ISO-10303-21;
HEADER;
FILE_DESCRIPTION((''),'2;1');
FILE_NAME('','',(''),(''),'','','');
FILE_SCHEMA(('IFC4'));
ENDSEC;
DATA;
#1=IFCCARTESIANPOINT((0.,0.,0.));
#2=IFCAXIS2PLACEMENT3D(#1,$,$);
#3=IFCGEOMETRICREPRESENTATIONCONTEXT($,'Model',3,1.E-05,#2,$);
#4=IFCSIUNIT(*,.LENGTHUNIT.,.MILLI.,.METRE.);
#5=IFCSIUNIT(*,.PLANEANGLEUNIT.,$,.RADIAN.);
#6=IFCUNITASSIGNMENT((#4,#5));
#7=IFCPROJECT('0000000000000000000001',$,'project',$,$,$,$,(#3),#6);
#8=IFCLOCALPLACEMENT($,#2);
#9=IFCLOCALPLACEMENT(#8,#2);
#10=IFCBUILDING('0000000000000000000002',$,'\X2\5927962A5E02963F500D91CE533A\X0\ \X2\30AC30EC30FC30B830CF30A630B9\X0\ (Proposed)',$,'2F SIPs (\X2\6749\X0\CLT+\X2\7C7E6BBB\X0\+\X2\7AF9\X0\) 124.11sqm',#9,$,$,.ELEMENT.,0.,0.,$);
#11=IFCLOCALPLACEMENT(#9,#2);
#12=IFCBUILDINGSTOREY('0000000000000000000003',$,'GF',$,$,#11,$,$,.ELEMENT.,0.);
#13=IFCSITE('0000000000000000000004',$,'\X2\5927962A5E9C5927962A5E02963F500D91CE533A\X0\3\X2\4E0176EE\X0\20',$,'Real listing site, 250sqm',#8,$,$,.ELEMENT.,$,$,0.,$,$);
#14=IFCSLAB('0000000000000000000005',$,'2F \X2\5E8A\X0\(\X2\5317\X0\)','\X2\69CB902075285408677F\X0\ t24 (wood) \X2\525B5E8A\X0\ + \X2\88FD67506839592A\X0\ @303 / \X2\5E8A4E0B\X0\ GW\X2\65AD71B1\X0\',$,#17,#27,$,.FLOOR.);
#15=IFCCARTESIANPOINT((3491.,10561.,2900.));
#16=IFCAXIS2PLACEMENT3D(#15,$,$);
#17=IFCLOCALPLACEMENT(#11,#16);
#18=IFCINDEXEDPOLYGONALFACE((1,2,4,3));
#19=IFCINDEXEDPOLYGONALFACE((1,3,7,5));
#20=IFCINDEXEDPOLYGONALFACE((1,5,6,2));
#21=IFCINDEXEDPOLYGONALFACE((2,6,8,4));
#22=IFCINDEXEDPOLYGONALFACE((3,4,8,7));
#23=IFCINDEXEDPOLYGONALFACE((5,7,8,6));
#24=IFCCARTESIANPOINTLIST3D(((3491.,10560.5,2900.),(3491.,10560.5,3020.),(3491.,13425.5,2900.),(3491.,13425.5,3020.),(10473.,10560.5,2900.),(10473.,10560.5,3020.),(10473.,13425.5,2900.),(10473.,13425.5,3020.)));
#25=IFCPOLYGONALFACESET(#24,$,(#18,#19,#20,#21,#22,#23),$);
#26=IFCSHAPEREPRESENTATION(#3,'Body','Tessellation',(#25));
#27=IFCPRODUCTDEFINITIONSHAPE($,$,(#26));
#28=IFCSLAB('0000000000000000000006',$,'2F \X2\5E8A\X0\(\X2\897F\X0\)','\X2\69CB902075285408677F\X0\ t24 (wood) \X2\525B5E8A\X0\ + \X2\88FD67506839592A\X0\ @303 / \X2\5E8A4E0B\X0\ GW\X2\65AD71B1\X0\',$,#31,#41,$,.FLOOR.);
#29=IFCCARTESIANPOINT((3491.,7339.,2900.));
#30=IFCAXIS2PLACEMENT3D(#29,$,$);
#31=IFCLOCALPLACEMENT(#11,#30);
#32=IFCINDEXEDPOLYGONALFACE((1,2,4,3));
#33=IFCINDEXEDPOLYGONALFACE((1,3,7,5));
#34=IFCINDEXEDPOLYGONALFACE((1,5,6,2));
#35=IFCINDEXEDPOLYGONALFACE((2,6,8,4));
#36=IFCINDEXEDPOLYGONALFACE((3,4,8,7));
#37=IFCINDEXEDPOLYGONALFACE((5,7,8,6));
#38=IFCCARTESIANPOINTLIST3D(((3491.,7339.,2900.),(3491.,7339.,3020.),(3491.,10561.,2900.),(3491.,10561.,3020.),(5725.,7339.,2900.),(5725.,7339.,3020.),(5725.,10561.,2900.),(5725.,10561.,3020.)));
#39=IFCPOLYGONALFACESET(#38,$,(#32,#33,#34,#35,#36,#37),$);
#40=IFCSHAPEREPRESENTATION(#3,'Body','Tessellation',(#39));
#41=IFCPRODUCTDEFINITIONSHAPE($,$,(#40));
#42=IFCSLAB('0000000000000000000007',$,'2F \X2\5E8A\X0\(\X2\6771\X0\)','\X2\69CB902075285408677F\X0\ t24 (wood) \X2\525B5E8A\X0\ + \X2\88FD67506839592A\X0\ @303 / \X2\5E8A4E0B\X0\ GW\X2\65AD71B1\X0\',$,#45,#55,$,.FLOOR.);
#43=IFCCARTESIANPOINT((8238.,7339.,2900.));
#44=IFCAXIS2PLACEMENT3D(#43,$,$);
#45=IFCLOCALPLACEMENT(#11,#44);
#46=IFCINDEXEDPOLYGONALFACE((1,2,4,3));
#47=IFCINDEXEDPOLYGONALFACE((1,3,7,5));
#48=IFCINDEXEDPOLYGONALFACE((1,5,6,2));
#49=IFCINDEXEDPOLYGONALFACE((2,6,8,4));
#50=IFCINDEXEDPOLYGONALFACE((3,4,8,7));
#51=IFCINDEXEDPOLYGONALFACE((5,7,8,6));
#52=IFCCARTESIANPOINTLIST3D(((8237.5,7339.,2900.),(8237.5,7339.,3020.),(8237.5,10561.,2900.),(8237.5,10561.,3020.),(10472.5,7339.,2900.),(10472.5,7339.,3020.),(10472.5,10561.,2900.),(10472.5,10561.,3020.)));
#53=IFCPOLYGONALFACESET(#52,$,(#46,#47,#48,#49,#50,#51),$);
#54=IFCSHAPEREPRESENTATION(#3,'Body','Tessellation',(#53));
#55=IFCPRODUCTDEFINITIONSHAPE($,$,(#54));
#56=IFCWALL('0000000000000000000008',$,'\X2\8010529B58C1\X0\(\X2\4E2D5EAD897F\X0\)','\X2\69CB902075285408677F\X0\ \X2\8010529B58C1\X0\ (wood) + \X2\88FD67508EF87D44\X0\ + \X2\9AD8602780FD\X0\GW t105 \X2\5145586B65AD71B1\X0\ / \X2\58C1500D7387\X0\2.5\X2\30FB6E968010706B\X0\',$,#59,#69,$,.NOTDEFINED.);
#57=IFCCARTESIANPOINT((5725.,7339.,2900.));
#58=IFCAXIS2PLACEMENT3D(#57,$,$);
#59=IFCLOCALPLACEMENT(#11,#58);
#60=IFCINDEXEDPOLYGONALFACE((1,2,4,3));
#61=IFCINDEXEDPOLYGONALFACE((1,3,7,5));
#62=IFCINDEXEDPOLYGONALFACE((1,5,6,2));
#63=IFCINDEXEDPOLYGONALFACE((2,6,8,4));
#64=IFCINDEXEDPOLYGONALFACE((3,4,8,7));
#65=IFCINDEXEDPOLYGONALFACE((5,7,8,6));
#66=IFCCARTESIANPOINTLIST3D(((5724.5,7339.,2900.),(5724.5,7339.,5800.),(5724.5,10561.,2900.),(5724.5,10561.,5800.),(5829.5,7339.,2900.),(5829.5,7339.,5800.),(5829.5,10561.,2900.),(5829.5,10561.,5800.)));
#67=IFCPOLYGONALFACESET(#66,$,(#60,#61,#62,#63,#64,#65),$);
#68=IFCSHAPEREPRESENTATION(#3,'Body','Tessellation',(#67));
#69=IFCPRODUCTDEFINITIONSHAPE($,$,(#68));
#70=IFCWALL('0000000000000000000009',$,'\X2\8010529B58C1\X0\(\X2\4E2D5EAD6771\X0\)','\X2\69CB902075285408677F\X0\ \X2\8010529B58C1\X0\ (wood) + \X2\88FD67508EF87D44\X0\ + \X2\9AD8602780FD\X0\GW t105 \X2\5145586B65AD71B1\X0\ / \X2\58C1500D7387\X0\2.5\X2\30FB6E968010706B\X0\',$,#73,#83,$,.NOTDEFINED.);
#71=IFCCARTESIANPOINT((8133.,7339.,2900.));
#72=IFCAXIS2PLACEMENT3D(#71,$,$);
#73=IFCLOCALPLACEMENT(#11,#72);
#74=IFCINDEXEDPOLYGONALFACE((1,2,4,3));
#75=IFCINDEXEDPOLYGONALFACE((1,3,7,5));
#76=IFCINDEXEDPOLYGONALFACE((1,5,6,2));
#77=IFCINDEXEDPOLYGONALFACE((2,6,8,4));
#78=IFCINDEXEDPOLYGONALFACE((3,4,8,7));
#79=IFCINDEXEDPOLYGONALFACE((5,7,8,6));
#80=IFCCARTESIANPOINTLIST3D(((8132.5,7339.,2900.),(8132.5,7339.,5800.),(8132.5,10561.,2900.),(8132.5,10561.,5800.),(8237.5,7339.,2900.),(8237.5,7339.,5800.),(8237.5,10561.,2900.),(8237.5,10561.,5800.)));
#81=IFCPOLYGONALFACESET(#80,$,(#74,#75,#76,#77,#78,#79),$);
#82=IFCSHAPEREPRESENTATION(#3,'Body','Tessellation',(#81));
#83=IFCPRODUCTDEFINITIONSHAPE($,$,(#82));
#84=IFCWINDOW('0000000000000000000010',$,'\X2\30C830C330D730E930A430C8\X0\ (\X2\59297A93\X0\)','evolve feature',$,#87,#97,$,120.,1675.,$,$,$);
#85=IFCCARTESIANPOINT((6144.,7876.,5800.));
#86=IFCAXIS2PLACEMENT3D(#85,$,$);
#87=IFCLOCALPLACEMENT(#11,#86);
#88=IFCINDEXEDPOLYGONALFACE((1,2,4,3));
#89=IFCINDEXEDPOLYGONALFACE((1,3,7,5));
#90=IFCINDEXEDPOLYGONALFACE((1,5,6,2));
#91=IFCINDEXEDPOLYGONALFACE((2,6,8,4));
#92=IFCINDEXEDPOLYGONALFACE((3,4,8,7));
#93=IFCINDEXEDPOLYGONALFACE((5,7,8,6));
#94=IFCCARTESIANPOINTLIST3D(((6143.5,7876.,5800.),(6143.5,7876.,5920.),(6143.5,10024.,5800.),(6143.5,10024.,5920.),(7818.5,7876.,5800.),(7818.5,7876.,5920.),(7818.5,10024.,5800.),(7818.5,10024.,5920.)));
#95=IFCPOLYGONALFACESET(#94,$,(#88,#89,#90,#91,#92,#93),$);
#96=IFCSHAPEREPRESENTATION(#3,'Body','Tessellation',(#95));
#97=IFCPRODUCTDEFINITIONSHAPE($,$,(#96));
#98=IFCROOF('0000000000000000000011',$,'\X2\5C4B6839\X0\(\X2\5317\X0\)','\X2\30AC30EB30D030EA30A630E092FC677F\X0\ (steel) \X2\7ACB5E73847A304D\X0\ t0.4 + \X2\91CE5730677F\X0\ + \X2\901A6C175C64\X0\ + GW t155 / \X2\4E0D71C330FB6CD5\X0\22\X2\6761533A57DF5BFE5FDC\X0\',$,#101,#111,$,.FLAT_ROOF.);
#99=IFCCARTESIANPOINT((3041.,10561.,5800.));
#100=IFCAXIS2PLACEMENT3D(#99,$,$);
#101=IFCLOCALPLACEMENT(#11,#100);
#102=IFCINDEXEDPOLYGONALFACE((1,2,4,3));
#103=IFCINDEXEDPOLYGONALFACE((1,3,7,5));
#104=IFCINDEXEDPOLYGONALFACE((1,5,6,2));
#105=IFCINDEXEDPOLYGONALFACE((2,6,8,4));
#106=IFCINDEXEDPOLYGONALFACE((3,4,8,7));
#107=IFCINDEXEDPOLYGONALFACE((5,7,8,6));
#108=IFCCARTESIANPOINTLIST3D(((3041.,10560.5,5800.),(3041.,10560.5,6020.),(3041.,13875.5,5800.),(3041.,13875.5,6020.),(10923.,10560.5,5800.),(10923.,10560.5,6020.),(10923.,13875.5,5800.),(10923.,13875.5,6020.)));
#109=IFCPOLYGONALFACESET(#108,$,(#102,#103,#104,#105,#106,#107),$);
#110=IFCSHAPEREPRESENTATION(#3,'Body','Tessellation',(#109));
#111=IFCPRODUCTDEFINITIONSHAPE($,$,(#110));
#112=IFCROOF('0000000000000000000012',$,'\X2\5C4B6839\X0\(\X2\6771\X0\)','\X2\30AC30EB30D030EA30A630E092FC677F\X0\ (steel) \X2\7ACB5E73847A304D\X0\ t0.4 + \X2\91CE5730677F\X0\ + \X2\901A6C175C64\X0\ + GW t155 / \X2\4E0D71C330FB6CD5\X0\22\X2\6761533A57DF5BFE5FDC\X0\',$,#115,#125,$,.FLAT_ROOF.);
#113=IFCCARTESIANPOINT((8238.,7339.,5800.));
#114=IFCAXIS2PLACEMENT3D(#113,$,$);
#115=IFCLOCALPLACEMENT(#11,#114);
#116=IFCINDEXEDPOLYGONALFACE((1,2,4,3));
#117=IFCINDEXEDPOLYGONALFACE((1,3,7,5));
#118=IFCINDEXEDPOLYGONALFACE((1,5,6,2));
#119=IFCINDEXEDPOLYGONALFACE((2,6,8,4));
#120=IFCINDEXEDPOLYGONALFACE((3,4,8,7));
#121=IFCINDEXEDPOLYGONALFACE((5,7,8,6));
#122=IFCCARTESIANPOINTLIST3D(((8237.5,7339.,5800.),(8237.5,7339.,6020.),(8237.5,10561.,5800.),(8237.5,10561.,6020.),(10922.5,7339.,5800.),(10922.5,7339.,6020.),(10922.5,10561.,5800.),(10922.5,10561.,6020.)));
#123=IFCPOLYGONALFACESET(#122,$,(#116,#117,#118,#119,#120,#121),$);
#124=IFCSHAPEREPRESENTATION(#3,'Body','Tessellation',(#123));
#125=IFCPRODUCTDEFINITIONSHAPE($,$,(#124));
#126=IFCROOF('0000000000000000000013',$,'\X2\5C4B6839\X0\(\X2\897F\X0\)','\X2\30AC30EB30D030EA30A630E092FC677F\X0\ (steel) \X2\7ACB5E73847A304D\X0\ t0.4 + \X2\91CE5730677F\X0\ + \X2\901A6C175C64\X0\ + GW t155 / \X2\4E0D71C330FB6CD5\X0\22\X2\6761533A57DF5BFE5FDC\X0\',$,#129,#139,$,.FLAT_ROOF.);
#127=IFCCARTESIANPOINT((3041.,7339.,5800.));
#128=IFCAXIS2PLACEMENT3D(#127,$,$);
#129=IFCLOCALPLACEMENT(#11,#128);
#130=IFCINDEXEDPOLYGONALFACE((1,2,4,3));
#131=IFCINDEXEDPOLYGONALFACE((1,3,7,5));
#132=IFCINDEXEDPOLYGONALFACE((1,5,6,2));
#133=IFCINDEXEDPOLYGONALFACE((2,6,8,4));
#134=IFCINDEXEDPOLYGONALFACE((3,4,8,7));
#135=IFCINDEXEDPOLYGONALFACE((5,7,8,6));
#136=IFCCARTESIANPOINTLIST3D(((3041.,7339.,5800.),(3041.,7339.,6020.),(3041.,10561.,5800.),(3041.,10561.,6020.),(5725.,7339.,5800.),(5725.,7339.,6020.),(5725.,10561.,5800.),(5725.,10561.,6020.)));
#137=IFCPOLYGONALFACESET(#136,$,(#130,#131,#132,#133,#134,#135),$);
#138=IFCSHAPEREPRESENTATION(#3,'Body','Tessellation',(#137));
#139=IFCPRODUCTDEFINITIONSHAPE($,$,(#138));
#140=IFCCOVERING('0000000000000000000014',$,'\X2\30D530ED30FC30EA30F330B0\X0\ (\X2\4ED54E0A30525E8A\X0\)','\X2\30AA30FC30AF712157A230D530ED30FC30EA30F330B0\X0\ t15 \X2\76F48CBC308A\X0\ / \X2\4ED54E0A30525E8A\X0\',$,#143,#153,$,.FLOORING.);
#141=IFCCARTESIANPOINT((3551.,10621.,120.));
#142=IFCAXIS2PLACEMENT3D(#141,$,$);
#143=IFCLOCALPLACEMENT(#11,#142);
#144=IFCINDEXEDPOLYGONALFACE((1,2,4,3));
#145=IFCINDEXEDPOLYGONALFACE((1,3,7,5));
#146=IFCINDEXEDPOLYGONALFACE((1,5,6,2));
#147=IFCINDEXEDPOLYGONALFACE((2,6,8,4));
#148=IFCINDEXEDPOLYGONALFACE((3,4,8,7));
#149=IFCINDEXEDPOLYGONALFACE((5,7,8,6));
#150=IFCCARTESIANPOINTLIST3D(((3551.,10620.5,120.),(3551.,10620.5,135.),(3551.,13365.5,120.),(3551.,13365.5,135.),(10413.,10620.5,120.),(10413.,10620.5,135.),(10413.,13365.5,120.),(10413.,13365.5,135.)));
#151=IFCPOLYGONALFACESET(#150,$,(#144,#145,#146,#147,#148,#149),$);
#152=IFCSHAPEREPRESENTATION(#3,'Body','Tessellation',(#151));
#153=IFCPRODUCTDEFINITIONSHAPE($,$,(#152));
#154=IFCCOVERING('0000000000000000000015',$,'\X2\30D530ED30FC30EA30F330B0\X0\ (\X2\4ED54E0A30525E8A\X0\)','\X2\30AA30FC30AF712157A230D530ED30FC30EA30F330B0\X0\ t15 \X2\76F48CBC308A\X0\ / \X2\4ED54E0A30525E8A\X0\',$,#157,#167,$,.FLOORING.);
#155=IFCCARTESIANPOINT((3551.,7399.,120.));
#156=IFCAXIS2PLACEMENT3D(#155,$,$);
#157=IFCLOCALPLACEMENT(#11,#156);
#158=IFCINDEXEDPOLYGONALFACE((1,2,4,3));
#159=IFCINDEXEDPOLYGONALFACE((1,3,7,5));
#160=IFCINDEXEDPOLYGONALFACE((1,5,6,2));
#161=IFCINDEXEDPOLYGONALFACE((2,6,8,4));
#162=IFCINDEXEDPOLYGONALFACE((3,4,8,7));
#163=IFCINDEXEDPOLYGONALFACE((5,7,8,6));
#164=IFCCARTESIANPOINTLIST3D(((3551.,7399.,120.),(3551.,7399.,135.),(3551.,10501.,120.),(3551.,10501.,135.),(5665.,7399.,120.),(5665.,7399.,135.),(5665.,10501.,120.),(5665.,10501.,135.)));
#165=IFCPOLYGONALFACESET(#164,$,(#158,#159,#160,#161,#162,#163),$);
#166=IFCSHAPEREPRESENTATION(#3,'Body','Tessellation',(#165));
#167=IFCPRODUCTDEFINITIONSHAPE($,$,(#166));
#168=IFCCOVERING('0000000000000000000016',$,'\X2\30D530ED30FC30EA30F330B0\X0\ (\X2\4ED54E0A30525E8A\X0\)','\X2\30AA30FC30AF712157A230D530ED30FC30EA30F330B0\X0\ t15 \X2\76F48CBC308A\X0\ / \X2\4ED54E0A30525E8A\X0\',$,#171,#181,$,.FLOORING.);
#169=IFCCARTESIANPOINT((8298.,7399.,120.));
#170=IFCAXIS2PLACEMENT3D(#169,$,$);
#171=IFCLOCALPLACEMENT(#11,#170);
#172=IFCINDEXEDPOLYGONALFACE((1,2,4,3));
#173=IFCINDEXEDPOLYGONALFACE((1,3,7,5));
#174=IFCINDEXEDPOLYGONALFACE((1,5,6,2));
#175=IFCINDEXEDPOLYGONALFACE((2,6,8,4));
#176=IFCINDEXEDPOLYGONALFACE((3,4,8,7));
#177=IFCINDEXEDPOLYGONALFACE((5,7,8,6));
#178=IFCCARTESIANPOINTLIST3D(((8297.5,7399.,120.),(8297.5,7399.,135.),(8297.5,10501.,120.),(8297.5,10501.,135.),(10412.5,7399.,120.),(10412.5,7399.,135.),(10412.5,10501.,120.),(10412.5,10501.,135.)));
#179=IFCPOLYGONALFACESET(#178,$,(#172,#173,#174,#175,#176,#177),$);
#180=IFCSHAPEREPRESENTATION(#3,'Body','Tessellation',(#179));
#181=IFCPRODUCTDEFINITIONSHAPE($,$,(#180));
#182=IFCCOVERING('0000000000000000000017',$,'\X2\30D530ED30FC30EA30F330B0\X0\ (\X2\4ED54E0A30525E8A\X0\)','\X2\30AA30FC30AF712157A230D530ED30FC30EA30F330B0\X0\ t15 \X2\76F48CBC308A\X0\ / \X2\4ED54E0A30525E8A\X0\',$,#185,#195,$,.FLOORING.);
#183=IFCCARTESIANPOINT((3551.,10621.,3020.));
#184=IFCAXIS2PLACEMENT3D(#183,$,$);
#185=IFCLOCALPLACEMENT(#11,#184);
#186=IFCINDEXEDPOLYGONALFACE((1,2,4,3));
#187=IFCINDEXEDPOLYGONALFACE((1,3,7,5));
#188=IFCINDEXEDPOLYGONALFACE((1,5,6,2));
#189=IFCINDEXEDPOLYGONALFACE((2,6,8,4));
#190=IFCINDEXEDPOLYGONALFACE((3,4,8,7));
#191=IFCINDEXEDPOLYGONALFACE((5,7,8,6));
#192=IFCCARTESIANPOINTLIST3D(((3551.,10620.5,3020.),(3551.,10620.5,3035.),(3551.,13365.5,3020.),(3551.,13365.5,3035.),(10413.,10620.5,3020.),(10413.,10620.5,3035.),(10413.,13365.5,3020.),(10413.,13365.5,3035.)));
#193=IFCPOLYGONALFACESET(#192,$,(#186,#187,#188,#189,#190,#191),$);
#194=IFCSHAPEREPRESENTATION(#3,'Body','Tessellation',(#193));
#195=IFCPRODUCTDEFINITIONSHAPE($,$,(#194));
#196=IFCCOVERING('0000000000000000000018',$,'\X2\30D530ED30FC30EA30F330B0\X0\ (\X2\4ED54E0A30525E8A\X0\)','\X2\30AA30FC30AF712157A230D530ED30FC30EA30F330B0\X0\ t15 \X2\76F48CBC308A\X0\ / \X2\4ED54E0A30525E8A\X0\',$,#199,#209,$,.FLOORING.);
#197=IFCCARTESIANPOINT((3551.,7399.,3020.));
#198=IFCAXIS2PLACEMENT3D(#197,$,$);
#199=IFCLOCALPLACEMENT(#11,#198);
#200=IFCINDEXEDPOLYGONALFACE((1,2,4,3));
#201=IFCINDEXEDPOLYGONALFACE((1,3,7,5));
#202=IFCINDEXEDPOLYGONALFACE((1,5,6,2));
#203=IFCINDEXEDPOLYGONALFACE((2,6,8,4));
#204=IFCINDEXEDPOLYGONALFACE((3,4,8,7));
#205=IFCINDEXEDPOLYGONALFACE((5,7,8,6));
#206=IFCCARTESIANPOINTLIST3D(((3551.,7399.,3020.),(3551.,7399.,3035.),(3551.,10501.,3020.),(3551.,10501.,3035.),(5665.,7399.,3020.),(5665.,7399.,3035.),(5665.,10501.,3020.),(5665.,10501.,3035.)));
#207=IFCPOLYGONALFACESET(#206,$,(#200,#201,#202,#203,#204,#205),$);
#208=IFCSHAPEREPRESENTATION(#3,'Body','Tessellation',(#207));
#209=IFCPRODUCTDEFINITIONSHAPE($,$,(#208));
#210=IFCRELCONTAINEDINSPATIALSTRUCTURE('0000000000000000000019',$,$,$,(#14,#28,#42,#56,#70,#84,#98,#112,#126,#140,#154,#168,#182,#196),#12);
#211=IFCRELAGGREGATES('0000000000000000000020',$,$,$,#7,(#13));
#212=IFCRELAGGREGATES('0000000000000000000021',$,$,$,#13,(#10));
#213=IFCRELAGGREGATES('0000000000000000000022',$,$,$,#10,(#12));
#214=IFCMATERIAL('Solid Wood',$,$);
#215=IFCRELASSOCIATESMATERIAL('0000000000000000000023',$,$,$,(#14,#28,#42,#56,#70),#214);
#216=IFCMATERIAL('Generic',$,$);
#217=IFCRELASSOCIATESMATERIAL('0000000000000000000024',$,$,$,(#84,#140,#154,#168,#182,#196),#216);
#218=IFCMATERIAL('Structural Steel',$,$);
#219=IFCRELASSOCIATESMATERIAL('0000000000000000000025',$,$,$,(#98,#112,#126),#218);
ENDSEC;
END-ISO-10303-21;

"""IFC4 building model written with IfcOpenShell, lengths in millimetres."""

from ifc_helpers import new_model, si_unit, frame, frame_2d, origin, place, context, project, spatial, rectangle, extrude, material, element, save


model = new_model("IFC4")

# Units and contexts
model_context = context("Model", 3, precision=1e-05, world=origin())
ifc_project = project(units=[si_unit("LENGTHUNIT", "METRE", prefix="MILLI"), si_unit("PLANEANGLEUNIT", "RADIAN")], contexts=[model_context])

# Site, building, storey
site_placement = place(None, origin())
site = spatial("IfcSite", under=ifc_project, at=site_placement, Name="大阪府大阪市阿倍野区3丁目20", ObjectType="Real listing site, 250sqm", CompositionType="ELEMENT", RefElevation=0.0)
building_placement = place(site_placement, origin())
building = spatial("IfcBuilding", under=site, at=building_placement, Name="大阪市阿倍野区 ガレージハウス (Proposed)", ObjectType="2F SIPs (杉CLT+籾殻+竹) 124.11sqm", CompositionType="ELEMENT", ElevationOfRefHeight=0.0, ElevationOfTerrain=0.0)
storey_placement = place(building_placement, origin())
storey = spatial("IfcBuildingStorey", under=building, at=storey_placement, Name="GF", CompositionType="ELEMENT", Elevation=0.0)

# Slabs
ifc_material_1 = material(Name="Solid Wood")
slab_1_placement = place(storey_placement, frame((3491.0, 10561.0, 2900.0)))
element("IfcSlab", 1, at=slab_1_placement, inside=storey, material=ifc_material_1, Name="2F 床(北)", Description="構造用合板 t24 (wood) 剛床 + 製材根太 @303 / 床下 GW断熱", PredefinedType="FLOOR", context=model_context, shape_type="SweptSolid", body=[
    extrude(rectangle(XDim=6982.0, YDim=2865.0, at=frame_2d((3491.0, 1432.0))), frame((3491.0, 10561.0, 2900.0)), (0.0, 0.0, 1.0), 120.0),
])
slab_2_placement = place(storey_placement, frame((3491.0, 7339.0, 2900.0)))
element("IfcSlab", 2, at=slab_2_placement, inside=storey, material=ifc_material_1, Name="2F 床(西)", Description="構造用合板 t24 (wood) 剛床 + 製材根太 @303 / 床下 GW断熱", PredefinedType="FLOOR", context=model_context, shape_type="SweptSolid", body=[
    extrude(rectangle(XDim=2234.0, YDim=3222.0, at=frame_2d((1117.0, 1611.0))), frame((3491.0, 7339.0, 2900.0)), (0.0, 0.0, 1.0), 120.0),
])
slab_3_placement = place(storey_placement, frame((8238.0, 7339.0, 2900.0)))
element("IfcSlab", 3, at=slab_3_placement, inside=storey, material=ifc_material_1, Name="2F 床(東)", Description="構造用合板 t24 (wood) 剛床 + 製材根太 @303 / 床下 GW断熱", PredefinedType="FLOOR", context=model_context, shape_type="SweptSolid", body=[
    extrude(rectangle(XDim=2235.0, YDim=3222.0, at=frame_2d((1117.0, 1611.0))), frame((8238.0, 7339.0, 2900.0)), (0.0, 0.0, 1.0), 120.0),
])

# Walls
wall_1_placement = place(storey_placement, frame((5725.0, 7339.0, 2900.0)))
element("IfcWall", 4, at=wall_1_placement, inside=storey, material=ifc_material_1, Name="耐力壁(中庭西)", Description="構造用合板 耐力壁 (wood) + 製材軸組 + 高性能GW t105 充填断熱 / 壁倍率2.5・準耐火", PredefinedType="NOTDEFINED", context=model_context, shape_type="SweptSolid", body=[
    extrude(rectangle(XDim=105.0, YDim=3222.0, at=frame_2d((52.0, 1611.0))), frame((5725.0, 7339.0, 2900.0)), (0.0, 0.0, 1.0), 2900.0),
])
wall_2_placement = place(storey_placement, frame((8133.0, 7339.0, 2900.0)))
element("IfcWall", 5, at=wall_2_placement, inside=storey, material=ifc_material_1, Name="耐力壁(中庭東)", Description="構造用合板 耐力壁 (wood) + 製材軸組 + 高性能GW t105 充填断熱 / 壁倍率2.5・準耐火", PredefinedType="NOTDEFINED", context=model_context, shape_type="SweptSolid", body=[
    extrude(rectangle(XDim=105.0, YDim=3222.0, at=frame_2d((52.0, 1611.0))), frame((8133.0, 7339.0, 2900.0)), (0.0, 0.0, 1.0), 2900.0),
])

# Window
ifc_material_2 = material(Name="Generic")
window_1_placement = place(storey_placement, frame((6144.0, 7876.0, 5800.0)))
element("IfcWindow", 6, at=window_1_placement, inside=storey, material=ifc_material_2, Name="トップライト (天窓)", Description="evolve feature", OverallHeight=120.0, OverallWidth=1675.0, context=model_context, shape_type="SweptSolid", body=[
    extrude(rectangle(XDim=1675.0, YDim=2148.0, at=frame_2d((837.0, 1074.0))), frame((6144.0, 7876.0, 5800.0)), (0.0, 0.0, 1.0), 120.0),
])

# Roofs
ifc_material_3 = material(Name="Structural Steel")
roof_1_placement = place(storey_placement, frame((3041.0, 10561.0, 5800.0)))
element("IfcRoof", 7, at=roof_1_placement, inside=storey, material=ifc_material_3, Name="屋根(北)", Description="ガルバリウム鋼板 (steel) 立平葺き t0.4 + 野地板 + 通気層 + GW t155 / 不燃・法22条区域対応", PredefinedType="FLAT_ROOF", context=model_context, shape_type="SweptSolid", body=[
    extrude(rectangle(XDim=7882.0, YDim=3315.0, at=frame_2d((3941.0, 1657.0))), frame((3041.0, 10561.0, 5800.0)), (0.0, 0.0, 1.0), 220.0),
])
roof_2_placement = place(storey_placement, frame((8238.0, 7339.0, 5800.0)))
element("IfcRoof", 8, at=roof_2_placement, inside=storey, material=ifc_material_3, Name="屋根(東)", Description="ガルバリウム鋼板 (steel) 立平葺き t0.4 + 野地板 + 通気層 + GW t155 / 不燃・法22条区域対応", PredefinedType="FLAT_ROOF", context=model_context, shape_type="SweptSolid", body=[
    extrude(rectangle(XDim=2685.0, YDim=3222.0, at=frame_2d((1342.0, 1611.0))), frame((8238.0, 7339.0, 5800.0)), (0.0, 0.0, 1.0), 220.0),
])
roof_3_placement = place(storey_placement, frame((3041.0, 7339.0, 5800.0)))
element("IfcRoof", 9, at=roof_3_placement, inside=storey, material=ifc_material_3, Name="屋根(西)", Description="ガルバリウム鋼板 (steel) 立平葺き t0.4 + 野地板 + 通気層 + GW t155 / 不燃・法22条区域対応", PredefinedType="FLAT_ROOF", context=model_context, shape_type="SweptSolid", body=[
    extrude(rectangle(XDim=2684.0, YDim=3222.0, at=frame_2d((1342.0, 1611.0))), frame((3041.0, 7339.0, 5800.0)), (0.0, 0.0, 1.0), 220.0),
])

# Coverings
covering_1_placement = place(storey_placement, frame((3551.0, 10621.0, 120.0)))
element("IfcCovering", 10, at=covering_1_placement, inside=storey, material=ifc_material_2, Name="フローリング (仕上げ床)", Description="オーク無垢フローリング t15 直貼り / 仕上げ床", PredefinedType="FLOORING", context=model_context, shape_type="SweptSolid", body=[
    extrude(rectangle(XDim=6862.0, YDim=2745.0, at=frame_2d((3431.0, 1372.0))), frame((3551.0, 10621.0, 120.0)), (0.0, 0.0, 1.0), 15.0),
])
covering_2_placement = place(storey_placement, frame((3551.0, 7399.0, 120.0)))
element("IfcCovering", 11, at=covering_2_placement, inside=storey, material=ifc_material_2, Name="フローリング (仕上げ床)", Description="オーク無垢フローリング t15 直貼り / 仕上げ床", PredefinedType="FLOORING", context=model_context, shape_type="SweptSolid", body=[
    extrude(rectangle(XDim=2114.0, YDim=3102.0, at=frame_2d((1057.0, 1551.0))), frame((3551.0, 7399.0, 120.0)), (0.0, 0.0, 1.0), 15.0),
])
covering_3_placement = place(storey_placement, frame((8298.0, 7399.0, 120.0)))
element("IfcCovering", 12, at=covering_3_placement, inside=storey, material=ifc_material_2, Name="フローリング (仕上げ床)", Description="オーク無垢フローリング t15 直貼り / 仕上げ床", PredefinedType="FLOORING", context=model_context, shape_type="SweptSolid", body=[
    extrude(rectangle(XDim=2115.0, YDim=3102.0, at=frame_2d((1057.0, 1551.0))), frame((8298.0, 7399.0, 120.0)), (0.0, 0.0, 1.0), 15.0),
])
covering_4_placement = place(storey_placement, frame((3551.0, 10621.0, 3020.0)))
element("IfcCovering", 13, at=covering_4_placement, inside=storey, material=ifc_material_2, Name="フローリング (仕上げ床)", Description="オーク無垢フローリング t15 直貼り / 仕上げ床", PredefinedType="FLOORING", context=model_context, shape_type="SweptSolid", body=[
    extrude(rectangle(XDim=6862.0, YDim=2745.0, at=frame_2d((3431.0, 1372.0))), frame((3551.0, 10621.0, 3020.0)), (0.0, 0.0, 1.0), 15.0),
])
covering_5_placement = place(storey_placement, frame((3551.0, 7399.0, 3020.0)))
element("IfcCovering", 14, at=covering_5_placement, inside=storey, material=ifc_material_2, Name="フローリング (仕上げ床)", Description="オーク無垢フローリング t15 直貼り / 仕上げ床", PredefinedType="FLOORING", context=model_context, shape_type="SweptSolid", body=[
    extrude(rectangle(XDim=2114.0, YDim=3102.0, at=frame_2d((1057.0, 1551.0))), frame((3551.0, 7399.0, 3020.0)), (0.0, 0.0, 1.0), 15.0),
])

save(model, "model.ifc")
